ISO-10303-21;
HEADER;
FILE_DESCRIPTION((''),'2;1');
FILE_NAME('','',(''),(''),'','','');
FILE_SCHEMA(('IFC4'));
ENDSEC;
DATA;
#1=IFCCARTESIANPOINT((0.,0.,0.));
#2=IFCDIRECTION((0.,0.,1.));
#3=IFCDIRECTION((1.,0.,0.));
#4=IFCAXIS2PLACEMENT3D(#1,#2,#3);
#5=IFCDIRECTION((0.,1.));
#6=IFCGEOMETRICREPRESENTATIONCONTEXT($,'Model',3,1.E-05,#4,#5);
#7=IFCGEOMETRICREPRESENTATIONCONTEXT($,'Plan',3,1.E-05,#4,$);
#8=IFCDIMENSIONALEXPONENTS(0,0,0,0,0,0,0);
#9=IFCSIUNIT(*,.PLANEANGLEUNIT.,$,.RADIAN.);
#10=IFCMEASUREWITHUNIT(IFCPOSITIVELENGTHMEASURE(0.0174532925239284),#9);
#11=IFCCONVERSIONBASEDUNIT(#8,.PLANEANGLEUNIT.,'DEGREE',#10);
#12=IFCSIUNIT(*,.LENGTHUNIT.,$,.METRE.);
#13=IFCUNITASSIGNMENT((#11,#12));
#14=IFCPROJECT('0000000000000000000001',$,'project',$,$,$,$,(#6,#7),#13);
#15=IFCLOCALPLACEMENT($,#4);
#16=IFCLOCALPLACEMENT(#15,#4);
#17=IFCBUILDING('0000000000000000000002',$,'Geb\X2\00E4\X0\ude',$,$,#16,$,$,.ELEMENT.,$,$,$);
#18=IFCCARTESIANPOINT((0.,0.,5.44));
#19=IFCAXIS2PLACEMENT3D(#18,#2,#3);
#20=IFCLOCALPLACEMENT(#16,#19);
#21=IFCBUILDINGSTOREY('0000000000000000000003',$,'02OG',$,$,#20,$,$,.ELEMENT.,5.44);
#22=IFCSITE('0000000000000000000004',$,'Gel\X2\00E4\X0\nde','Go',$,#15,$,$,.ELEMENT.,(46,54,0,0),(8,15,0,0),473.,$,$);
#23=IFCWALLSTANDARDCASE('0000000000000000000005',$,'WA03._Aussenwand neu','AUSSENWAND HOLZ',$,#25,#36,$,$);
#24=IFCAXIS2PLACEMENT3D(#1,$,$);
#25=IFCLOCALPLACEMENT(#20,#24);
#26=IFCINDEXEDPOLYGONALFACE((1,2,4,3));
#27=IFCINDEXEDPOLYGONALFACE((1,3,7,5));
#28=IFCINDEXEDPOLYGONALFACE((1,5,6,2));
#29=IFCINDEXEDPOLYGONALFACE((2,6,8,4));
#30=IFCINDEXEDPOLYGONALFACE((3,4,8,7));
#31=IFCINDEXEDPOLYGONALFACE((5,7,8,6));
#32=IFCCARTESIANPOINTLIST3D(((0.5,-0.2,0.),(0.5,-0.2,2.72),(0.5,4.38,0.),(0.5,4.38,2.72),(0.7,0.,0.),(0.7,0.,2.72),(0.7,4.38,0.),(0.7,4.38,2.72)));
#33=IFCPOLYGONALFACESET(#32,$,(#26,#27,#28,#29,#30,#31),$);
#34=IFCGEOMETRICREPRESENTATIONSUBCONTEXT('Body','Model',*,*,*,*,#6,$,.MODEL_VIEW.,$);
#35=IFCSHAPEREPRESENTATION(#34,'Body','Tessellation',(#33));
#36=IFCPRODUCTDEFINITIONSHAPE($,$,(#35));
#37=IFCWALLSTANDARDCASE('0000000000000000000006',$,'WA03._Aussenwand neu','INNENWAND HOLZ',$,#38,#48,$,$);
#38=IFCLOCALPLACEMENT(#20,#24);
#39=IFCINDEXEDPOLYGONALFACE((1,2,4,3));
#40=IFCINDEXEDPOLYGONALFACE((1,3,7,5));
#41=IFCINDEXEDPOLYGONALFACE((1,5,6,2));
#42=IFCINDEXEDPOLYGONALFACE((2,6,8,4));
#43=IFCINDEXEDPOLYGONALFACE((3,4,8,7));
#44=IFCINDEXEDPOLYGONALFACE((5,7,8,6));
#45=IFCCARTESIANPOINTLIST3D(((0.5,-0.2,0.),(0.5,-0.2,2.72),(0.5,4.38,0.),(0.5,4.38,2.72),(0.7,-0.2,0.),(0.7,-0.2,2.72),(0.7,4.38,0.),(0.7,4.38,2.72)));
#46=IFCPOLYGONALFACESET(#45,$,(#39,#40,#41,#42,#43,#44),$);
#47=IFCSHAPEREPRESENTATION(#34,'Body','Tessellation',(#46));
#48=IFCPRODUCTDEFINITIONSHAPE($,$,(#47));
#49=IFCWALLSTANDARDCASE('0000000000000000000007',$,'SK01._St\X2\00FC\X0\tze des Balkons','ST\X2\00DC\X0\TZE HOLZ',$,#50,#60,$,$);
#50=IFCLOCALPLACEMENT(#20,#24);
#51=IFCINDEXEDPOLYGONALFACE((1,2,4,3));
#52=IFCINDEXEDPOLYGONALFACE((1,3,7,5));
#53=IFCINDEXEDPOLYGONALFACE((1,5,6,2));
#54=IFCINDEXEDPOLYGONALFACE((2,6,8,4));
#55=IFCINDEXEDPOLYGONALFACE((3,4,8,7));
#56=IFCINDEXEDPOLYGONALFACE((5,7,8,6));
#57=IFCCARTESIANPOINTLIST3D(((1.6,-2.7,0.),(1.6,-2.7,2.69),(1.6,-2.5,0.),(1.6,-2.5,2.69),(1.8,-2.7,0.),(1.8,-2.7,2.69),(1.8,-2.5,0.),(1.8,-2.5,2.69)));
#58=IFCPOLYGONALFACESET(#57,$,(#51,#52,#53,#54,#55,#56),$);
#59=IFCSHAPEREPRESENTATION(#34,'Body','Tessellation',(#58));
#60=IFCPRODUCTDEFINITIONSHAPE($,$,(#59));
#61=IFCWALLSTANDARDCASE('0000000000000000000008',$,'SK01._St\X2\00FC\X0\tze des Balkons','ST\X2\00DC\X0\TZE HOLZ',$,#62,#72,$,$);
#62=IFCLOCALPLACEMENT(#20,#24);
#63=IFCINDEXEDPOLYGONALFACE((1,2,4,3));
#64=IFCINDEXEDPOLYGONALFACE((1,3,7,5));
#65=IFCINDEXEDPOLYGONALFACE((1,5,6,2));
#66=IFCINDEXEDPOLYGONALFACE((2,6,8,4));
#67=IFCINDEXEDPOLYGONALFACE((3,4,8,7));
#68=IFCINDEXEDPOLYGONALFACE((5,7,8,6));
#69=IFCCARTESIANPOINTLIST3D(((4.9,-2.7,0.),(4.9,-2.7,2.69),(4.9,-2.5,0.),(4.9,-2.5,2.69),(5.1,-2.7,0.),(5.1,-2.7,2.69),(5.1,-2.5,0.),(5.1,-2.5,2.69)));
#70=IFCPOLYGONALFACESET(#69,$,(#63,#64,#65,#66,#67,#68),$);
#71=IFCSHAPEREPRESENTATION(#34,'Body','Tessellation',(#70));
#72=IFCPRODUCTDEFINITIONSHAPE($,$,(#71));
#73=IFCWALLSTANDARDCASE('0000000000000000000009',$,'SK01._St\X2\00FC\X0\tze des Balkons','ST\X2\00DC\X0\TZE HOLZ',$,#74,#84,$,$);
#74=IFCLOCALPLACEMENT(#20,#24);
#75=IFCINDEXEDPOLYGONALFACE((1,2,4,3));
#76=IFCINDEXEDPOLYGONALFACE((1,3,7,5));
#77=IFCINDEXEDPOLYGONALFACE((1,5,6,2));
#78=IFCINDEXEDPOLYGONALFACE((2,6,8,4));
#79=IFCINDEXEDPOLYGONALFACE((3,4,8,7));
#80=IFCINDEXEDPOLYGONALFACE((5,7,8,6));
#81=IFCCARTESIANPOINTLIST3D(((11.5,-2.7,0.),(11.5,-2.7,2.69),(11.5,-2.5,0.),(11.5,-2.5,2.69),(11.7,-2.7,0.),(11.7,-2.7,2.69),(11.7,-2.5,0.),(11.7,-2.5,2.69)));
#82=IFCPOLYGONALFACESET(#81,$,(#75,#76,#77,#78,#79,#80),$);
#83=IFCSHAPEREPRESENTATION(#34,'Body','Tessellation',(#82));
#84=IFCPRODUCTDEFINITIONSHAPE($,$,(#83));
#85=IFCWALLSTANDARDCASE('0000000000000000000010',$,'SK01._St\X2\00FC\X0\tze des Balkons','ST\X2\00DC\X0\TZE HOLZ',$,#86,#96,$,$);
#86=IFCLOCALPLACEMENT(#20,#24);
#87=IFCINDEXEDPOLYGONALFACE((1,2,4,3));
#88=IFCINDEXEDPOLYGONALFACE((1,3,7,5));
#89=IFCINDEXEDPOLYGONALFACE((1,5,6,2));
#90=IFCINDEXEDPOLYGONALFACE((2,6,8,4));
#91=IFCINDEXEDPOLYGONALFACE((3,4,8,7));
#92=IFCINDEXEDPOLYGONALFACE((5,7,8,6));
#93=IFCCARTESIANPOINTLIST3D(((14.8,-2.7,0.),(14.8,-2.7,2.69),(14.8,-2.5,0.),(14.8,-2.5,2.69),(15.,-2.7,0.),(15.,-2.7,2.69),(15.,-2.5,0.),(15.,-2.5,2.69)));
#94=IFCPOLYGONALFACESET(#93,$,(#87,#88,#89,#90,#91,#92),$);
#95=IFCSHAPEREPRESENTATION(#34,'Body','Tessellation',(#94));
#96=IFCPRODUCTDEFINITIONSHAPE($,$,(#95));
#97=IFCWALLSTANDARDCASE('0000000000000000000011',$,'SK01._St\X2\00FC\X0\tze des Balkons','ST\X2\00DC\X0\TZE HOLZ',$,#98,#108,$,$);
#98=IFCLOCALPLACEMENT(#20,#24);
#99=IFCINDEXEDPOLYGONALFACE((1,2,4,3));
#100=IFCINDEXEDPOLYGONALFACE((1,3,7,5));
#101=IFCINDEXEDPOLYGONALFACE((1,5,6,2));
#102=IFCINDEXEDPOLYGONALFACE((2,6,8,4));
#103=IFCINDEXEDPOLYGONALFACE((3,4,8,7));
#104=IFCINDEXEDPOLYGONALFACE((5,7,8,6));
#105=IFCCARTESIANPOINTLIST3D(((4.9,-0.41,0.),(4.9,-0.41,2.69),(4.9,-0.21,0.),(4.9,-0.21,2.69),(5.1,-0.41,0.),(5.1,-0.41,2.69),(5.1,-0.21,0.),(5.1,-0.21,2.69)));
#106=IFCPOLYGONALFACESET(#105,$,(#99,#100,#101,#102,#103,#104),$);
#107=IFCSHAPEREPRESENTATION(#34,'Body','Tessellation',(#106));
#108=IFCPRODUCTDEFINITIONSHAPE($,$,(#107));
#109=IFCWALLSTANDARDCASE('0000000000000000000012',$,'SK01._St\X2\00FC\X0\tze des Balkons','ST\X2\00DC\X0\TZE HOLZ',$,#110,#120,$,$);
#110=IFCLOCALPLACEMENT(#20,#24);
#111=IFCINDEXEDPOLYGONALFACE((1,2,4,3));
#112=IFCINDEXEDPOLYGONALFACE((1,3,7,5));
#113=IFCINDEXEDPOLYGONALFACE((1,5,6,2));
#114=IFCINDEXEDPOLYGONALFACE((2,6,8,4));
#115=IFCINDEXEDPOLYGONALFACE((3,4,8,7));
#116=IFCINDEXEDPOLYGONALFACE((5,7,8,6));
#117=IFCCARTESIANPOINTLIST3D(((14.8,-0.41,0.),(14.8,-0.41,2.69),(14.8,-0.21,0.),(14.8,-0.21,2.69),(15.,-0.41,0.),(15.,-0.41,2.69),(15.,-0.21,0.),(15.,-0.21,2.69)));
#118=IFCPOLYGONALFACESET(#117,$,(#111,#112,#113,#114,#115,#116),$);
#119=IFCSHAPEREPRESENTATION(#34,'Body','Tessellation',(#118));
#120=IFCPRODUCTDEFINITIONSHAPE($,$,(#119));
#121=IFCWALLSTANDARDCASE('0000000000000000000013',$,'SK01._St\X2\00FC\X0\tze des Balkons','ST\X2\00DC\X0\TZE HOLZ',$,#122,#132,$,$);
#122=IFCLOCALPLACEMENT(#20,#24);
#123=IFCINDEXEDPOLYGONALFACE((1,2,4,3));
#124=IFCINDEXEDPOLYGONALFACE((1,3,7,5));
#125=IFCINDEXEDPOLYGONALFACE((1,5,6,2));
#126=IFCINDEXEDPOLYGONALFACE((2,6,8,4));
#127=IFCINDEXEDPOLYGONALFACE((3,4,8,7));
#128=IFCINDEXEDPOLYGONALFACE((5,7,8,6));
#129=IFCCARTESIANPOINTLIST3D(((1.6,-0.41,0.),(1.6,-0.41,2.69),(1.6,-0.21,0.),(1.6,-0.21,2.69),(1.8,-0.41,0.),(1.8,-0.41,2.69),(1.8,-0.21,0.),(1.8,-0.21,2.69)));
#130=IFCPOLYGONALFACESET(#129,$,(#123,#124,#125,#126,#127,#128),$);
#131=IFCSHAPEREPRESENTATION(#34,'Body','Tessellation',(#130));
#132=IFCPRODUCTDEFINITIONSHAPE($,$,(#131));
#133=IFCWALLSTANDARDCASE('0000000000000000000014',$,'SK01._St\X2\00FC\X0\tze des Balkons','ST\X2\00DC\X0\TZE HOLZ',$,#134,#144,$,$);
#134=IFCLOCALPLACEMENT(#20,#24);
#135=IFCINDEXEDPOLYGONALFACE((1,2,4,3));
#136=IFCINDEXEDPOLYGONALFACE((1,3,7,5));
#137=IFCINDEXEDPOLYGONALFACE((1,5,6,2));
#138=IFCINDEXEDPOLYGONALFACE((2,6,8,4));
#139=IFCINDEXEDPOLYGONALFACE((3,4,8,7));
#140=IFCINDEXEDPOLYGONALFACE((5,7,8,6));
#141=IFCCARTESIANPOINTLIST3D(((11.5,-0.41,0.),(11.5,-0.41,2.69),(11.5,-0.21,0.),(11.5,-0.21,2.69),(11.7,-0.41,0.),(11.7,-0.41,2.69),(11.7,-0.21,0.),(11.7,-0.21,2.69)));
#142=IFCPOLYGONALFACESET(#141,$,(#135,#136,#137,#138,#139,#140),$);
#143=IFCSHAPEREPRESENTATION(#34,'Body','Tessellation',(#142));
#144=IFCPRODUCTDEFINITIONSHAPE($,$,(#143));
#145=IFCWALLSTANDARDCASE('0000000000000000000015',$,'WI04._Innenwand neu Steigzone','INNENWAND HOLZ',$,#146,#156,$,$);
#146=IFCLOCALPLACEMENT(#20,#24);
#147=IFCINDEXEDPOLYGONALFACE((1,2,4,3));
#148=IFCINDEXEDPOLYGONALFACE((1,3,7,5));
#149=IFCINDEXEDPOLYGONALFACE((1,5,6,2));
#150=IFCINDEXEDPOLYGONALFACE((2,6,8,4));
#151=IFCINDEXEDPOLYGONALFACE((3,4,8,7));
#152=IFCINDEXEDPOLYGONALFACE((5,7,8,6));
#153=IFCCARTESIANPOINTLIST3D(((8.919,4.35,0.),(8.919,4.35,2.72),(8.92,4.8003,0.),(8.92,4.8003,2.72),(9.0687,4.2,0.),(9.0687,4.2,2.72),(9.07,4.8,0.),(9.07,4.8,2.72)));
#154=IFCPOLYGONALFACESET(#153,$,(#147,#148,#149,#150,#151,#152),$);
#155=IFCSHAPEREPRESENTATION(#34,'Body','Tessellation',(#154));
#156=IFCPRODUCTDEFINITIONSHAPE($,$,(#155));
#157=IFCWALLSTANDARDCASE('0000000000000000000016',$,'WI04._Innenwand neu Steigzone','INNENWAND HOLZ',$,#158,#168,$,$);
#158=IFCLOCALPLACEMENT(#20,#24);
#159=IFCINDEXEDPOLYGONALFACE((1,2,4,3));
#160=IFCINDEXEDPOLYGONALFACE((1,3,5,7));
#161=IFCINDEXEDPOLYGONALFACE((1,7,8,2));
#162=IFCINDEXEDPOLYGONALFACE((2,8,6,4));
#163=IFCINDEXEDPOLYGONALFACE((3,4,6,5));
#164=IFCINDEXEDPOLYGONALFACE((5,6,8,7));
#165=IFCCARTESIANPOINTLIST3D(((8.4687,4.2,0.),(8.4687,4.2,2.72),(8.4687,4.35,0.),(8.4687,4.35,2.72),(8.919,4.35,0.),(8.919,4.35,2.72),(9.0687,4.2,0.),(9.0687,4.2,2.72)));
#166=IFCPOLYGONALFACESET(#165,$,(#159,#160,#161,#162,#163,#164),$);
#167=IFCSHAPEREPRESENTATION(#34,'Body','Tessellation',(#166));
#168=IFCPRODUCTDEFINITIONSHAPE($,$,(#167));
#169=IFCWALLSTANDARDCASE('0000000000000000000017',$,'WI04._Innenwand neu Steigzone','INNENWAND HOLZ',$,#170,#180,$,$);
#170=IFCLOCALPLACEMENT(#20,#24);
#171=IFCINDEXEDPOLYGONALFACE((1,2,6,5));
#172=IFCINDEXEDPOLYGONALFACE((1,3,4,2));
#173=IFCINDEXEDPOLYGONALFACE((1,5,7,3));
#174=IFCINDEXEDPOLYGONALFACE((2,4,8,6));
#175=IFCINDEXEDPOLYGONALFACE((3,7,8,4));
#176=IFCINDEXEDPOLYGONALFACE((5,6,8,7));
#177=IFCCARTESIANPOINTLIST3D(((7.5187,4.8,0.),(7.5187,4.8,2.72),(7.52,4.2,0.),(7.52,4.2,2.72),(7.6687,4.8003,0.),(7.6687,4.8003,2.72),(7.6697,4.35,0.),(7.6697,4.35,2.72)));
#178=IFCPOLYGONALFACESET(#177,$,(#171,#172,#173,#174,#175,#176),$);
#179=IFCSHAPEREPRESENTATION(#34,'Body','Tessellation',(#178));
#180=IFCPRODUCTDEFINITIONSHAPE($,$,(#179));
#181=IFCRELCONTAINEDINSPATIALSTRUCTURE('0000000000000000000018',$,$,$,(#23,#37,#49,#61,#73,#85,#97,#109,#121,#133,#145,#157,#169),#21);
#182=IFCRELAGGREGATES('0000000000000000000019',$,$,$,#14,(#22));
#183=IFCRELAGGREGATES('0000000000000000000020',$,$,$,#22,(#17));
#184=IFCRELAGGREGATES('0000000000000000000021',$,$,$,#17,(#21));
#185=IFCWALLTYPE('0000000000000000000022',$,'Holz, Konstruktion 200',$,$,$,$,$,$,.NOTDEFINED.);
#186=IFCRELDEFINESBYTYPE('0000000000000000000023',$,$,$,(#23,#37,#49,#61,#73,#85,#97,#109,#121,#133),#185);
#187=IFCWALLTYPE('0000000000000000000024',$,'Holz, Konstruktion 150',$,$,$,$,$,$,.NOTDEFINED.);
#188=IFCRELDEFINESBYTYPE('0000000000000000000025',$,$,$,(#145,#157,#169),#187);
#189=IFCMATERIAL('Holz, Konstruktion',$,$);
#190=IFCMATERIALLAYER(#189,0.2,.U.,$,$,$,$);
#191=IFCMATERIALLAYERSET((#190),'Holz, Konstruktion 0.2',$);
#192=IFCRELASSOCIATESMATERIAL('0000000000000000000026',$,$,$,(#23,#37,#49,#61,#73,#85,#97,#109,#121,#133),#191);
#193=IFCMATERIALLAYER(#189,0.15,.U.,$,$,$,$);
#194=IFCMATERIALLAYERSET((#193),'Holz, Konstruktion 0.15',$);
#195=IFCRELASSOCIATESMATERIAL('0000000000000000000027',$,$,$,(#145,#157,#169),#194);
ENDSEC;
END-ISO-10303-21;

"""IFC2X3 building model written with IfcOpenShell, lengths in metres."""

from ifc_helpers import new_model, entity, si_unit, converted_unit, direction, frame, origin_with_axes, place, context, subcontext, project, spatial, polyline, outline, extrude, material, layer, layer_set, layer_usage, type_object, element, save


model = new_model("IFC2X3")

# Units and contexts
model_context = context("Model", 3, precision=1e-05, world=origin_with_axes(), true_north=direction((0.0, 1.0)))
plan_context = context("Plan", 3, precision=1e-05, world=origin_with_axes())
body_context = subcontext(model_context, "Body", "Model", "MODEL_VIEW")
ifc_project = project(units=[converted_unit("PLANEANGLEUNIT", "DEGREE", entity("IfcPositiveLengthMeasure", 0.0174532925239284), si_unit("PLANEANGLEUNIT", "RADIAN"), dimensions=[0, 0, 0, 0, 0, 0, 0]), si_unit("LENGTHUNIT", "METRE")], contexts=[model_context, plan_context])

# Site, building, storey
site_placement = place(None, origin_with_axes())
site = spatial("IfcSite", under=ifc_project, at=site_placement, Name="Gelände", Description="Go", CompositionType="ELEMENT", RefLatitude=(46, 54, 0, 0), RefLongitude=(8, 15, 0, 0), RefElevation=473.0)
building_placement = place(site_placement, origin_with_axes())
building = spatial("IfcBuilding", under=site, at=building_placement, Name="Gebäude", CompositionType="ELEMENT")
storey_placement = place(building_placement, frame((0.0, 0.0, 5.44), z_axis=(0.0, 0.0, 1.0), x_axis=(1.0, 0.0, 0.0)))
storey = spatial("IfcBuildingStorey", under=building, at=storey_placement, Name="02OG", CompositionType="ELEMENT", Elevation=5.44)

# Shared definitions
ifc_material_1 = material(Name="Holz, Konstruktion")

# Walls
ifc_layer_1 = layer(ifc_material_1, 0.2, ventilated="UNKNOWN")
ifc_layer_set_1 = layer_set([ifc_layer_1], Name="Holz, Konstruktion 0.2")
wall_type_1 = type_object("IfcWallType", Name="Holz, Konstruktion 200", PredefinedType="NOTDEFINED")
ifc_layer_usage_1 = layer_usage(ifc_layer_set_1, "AXIS2", "POSITIVE", 0.0)
wall_1_placement = place(storey_placement, frame((0.5, 4.38, 0.0), z_axis=(0.0, 0.0, 1.0), x_axis=(0.0, -1.0, 0.0)))
element("IfcWallStandardCase", 1, at=wall_1_placement, inside=storey, type_object=wall_type_1, material=ifc_layer_usage_1, Name="WA03._Aussenwand neu", Description="AUSSENWAND HOLZ", context=body_context, shape_type="SweptSolid", body=[
    extrude(outline(polyline([(0.0, 0.0), (4.58, 0.0), (4.38, 0.2), (0.0, 0.2), (0.0, 0.0)])), origin_with_axes(), (0.0, 0.0, 1.0), 2.72),
])
ifc_layer_usage_2 = layer_usage(ifc_layer_set_1, "AXIS2", "POSITIVE", 0.0)
wall_2_placement = place(storey_placement, frame((0.5, 4.38, 0.0), z_axis=(0.0, 0.0, 1.0), x_axis=(0.0, -1.0, 0.0)))
element("IfcWallStandardCase", 2, at=wall_2_placement, inside=storey, type_object=wall_type_1, material=ifc_layer_usage_2, Name="WA03._Aussenwand neu", Description="INNENWAND HOLZ", context=body_context, shape_type="SweptSolid", body=[
    extrude(outline(polyline([(0.0, 0.0), (4.58, 0.0), (4.58, 0.2), (0.0, 0.2), (0.0, 0.0)])), origin_with_axes(), (0.0, 0.0, 1.0), 2.72),
])
ifc_layer_usage_3 = layer_usage(ifc_layer_set_1, "AXIS2", "NEGATIVE", 0.0)
wall_3_placement = place(storey_placement, frame((1.6, -2.7, 0.0), z_axis=(0.0, 0.0, 1.0), x_axis=(0.0, 1.0, 0.0)))
element("IfcWallStandardCase", 3, at=wall_3_placement, inside=storey, type_object=wall_type_1, material=ifc_layer_usage_3, Name="SK01._Stütze des Balkons", Description="STÜTZE HOLZ", context=body_context, shape_type="SweptSolid", body=[
    extrude(outline(polyline([(0.0, -0.2), (0.2, -0.2), (0.2, 0.0), (0.0, 0.0), (0.0, -0.2)])), origin_with_axes(), (0.0, 0.0, 1.0), 2.69),
])
ifc_layer_usage_4 = layer_usage(ifc_layer_set_1, "AXIS2", "POSITIVE", 0.0)
wall_4_placement = place(storey_placement, frame((5.1, -2.7, 0.0), z_axis=(0.0, 0.0, 1.0), x_axis=(0.0, 1.0, 0.0)))
element("IfcWallStandardCase", 4, at=wall_4_placement, inside=storey, type_object=wall_type_1, material=ifc_layer_usage_4, Name="SK01._Stütze des Balkons", Description="STÜTZE HOLZ", context=body_context, shape_type="SweptSolid", body=[
    extrude(outline(polyline([(0.0, 0.0), (0.2, 0.0), (0.2, 0.2), (0.0, 0.2), (0.0, 0.0)])), origin_with_axes(), (0.0, 0.0, 1.0), 2.69),
])
ifc_layer_usage_5 = layer_usage(ifc_layer_set_1, "AXIS2", "NEGATIVE", 0.0)
wall_5_placement = place(storey_placement, frame((11.5, -2.7, 0.0), z_axis=(0.0, 0.0, 1.0), x_axis=(0.0, 1.0, 0.0)))
element("IfcWallStandardCase", 5, at=wall_5_placement, inside=storey, type_object=wall_type_1, material=ifc_layer_usage_5, Name="SK01._Stütze des Balkons", Description="STÜTZE HOLZ", context=body_context, shape_type="SweptSolid", body=[
    extrude(outline(polyline([(0.0, -0.2), (0.2, -0.2), (0.2, 0.0), (0.0, 0.0), (0.0, -0.2)])), origin_with_axes(), (0.0, 0.0, 1.0), 2.69),
])
ifc_layer_usage_6 = layer_usage(ifc_layer_set_1, "AXIS2", "POSITIVE", 0.0)
wall_6_placement = place(storey_placement, frame((15.0, -2.7, 0.0), z_axis=(0.0, 0.0, 1.0), x_axis=(0.0, 1.0, 0.0)))
element("IfcWallStandardCase", 6, at=wall_6_placement, inside=storey, type_object=wall_type_1, material=ifc_layer_usage_6, Name="SK01._Stütze des Balkons", Description="STÜTZE HOLZ", context=body_context, shape_type="SweptSolid", body=[
    extrude(outline(polyline([(0.0, 0.0), (0.2, 0.0), (0.2, 0.2), (0.0, 0.2), (0.0, 0.0)])), origin_with_axes(), (0.0, 0.0, 1.0), 2.69),
])
ifc_layer_usage_7 = layer_usage(ifc_layer_set_1, "AXIS2", "POSITIVE", 0.0)
wall_7_placement = place(storey_placement, frame((5.1, -0.41, 0.0), z_axis=(0.0, 0.0, 1.0), x_axis=(0.0, 1.0, 0.0)))
element("IfcWallStandardCase", 7, at=wall_7_placement, inside=storey, type_object=wall_type_1, material=ifc_layer_usage_7, Name="SK01._Stütze des Balkons", Description="STÜTZE HOLZ", context=body_context, shape_type="SweptSolid", body=[
    extrude(outline(polyline([(0.0, 0.0), (0.2, 0.0), (0.2, 0.2), (0.0, 0.2), (0.0, 0.0)])), origin_with_axes(), (0.0, 0.0, 1.0), 2.69),
])
ifc_layer_usage_8 = layer_usage(ifc_layer_set_1, "AXIS2", "POSITIVE", 0.0)
wall_8_placement = place(storey_placement, frame((15.0, -0.41, 0.0), z_axis=(0.0, 0.0, 1.0), x_axis=(0.0, 1.0, 0.0)))
element("IfcWallStandardCase", 8, at=wall_8_placement, inside=storey, type_object=wall_type_1, material=ifc_layer_usage_8, Name="SK01._Stütze des Balkons", Description="STÜTZE HOLZ", context=body_context, shape_type="SweptSolid", body=[
    extrude(outline(polyline([(0.0, 0.0), (0.2, 0.0), (0.2, 0.2), (0.0, 0.2), (0.0, 0.0)])), origin_with_axes(), (0.0, 0.0, 1.0), 2.69),
])
ifc_layer_usage_9 = layer_usage(ifc_layer_set_1, "AXIS2", "NEGATIVE", 0.0)
wall_9_placement = place(storey_placement, frame((1.6, -0.41, 0.0), z_axis=(0.0, 0.0, 1.0), x_axis=(0.0, 1.0, 0.0)))
element("IfcWallStandardCase", 9, at=wall_9_placement, inside=storey, type_object=wall_type_1, material=ifc_layer_usage_9, Name="SK01._Stütze des Balkons", Description="STÜTZE HOLZ", context=body_context, shape_type="SweptSolid", body=[
    extrude(outline(polyline([(0.0, -0.2), (0.2, -0.2), (0.2, 0.0), (0.0, 0.0), (0.0, -0.2)])), origin_with_axes(), (0.0, 0.0, 1.0), 2.69),
])
ifc_layer_usage_10 = layer_usage(ifc_layer_set_1, "AXIS2", "NEGATIVE", 0.0)
wall_10_placement = place(storey_placement, frame((11.5, -0.41, 0.0), z_axis=(0.0, 0.0, 1.0), x_axis=(0.0, 1.0, 0.0)))
element("IfcWallStandardCase", 10, at=wall_10_placement, inside=storey, type_object=wall_type_1, material=ifc_layer_usage_10, Name="SK01._Stütze des Balkons", Description="STÜTZE HOLZ", context=body_context, shape_type="SweptSolid", body=[
    extrude(outline(polyline([(0.0, -0.2), (0.2, -0.2), (0.2, 0.0), (0.0, 0.0), (0.0, -0.2)])), origin_with_axes(), (0.0, 0.0, 1.0), 2.69),
])
ifc_layer_2 = layer(ifc_material_1, 0.15, ventilated="UNKNOWN")
ifc_layer_set_2 = layer_set([ifc_layer_2], Name="Holz, Konstruktion 0.15")
ifc_layer_usage_11 = layer_usage(ifc_layer_set_2, "AXIS2", "NEGATIVE", 0.0)
wall_type_2 = type_object("IfcWallType", Name="Holz, Konstruktion 150", PredefinedType="NOTDEFINED")
wall_11_placement = place(storey_placement, frame((9.07, 4.8, 0.0), z_axis=(0.0, 0.0, 1.0), x_axis=(-0.002118, -0.999998, 0.0)))
element("IfcWallStandardCase", 11, at=wall_11_placement, inside=storey, type_object=wall_type_2, material=ifc_layer_usage_11, Name="WI04._Innenwand neu Steigzone", Description="INNENWAND HOLZ", context=body_context, shape_type="SweptSolid", body=[
    extrude(outline(polyline([(0.0, -0.15), (0.4503, -0.15), (0.6, 0.0), (0.0, 0.0), (0.0, -0.15)])), origin_with_axes(), (0.0, 0.0, 1.0), 2.72),
])
ifc_layer_usage_12 = layer_usage(ifc_layer_set_2, "AXIS2", "NEGATIVE", 0.0)
wall_12_placement = place(storey_placement, frame((9.0687, 4.2, 0.0), z_axis=(0.0, 0.0, 1.0), x_axis=(-1.0, 0.0, 0.0)))
element("IfcWallStandardCase", 12, at=wall_12_placement, inside=storey, type_object=wall_type_2, material=ifc_layer_usage_12, Name="WI04._Innenwand neu Steigzone", Description="INNENWAND HOLZ", context=body_context, shape_type="SweptSolid", body=[
    extrude(outline(polyline([(0.1497, -0.15), (0.6, -0.15), (0.6, 0.0), (0.0, 0.0), (0.1497, -0.15)])), origin_with_axes(), (0.0, 0.0, 1.0), 2.72),
])
ifc_layer_usage_13 = layer_usage(ifc_layer_set_2, "AXIS2", "NEGATIVE", 0.0)
wall_13_placement = place(storey_placement, frame((7.52, 4.2, 0.0), z_axis=(0.0, 0.0, 1.0), x_axis=(-0.002118, 0.999998, 0.0)))
element("IfcWallStandardCase", 13, at=wall_13_placement, inside=storey, type_object=wall_type_2, material=ifc_layer_usage_13, Name="WI04._Innenwand neu Steigzone", Description="INNENWAND HOLZ", context=body_context, shape_type="SweptSolid", body=[
    extrude(outline(polyline([(0.1497, -0.15), (0.6, -0.15), (0.6, 0.0), (0.0, 0.0), (0.1497, -0.15)])), origin_with_axes(), (0.0, 0.0, 1.0), 2.72),
])

save(model, "model.ifc")
